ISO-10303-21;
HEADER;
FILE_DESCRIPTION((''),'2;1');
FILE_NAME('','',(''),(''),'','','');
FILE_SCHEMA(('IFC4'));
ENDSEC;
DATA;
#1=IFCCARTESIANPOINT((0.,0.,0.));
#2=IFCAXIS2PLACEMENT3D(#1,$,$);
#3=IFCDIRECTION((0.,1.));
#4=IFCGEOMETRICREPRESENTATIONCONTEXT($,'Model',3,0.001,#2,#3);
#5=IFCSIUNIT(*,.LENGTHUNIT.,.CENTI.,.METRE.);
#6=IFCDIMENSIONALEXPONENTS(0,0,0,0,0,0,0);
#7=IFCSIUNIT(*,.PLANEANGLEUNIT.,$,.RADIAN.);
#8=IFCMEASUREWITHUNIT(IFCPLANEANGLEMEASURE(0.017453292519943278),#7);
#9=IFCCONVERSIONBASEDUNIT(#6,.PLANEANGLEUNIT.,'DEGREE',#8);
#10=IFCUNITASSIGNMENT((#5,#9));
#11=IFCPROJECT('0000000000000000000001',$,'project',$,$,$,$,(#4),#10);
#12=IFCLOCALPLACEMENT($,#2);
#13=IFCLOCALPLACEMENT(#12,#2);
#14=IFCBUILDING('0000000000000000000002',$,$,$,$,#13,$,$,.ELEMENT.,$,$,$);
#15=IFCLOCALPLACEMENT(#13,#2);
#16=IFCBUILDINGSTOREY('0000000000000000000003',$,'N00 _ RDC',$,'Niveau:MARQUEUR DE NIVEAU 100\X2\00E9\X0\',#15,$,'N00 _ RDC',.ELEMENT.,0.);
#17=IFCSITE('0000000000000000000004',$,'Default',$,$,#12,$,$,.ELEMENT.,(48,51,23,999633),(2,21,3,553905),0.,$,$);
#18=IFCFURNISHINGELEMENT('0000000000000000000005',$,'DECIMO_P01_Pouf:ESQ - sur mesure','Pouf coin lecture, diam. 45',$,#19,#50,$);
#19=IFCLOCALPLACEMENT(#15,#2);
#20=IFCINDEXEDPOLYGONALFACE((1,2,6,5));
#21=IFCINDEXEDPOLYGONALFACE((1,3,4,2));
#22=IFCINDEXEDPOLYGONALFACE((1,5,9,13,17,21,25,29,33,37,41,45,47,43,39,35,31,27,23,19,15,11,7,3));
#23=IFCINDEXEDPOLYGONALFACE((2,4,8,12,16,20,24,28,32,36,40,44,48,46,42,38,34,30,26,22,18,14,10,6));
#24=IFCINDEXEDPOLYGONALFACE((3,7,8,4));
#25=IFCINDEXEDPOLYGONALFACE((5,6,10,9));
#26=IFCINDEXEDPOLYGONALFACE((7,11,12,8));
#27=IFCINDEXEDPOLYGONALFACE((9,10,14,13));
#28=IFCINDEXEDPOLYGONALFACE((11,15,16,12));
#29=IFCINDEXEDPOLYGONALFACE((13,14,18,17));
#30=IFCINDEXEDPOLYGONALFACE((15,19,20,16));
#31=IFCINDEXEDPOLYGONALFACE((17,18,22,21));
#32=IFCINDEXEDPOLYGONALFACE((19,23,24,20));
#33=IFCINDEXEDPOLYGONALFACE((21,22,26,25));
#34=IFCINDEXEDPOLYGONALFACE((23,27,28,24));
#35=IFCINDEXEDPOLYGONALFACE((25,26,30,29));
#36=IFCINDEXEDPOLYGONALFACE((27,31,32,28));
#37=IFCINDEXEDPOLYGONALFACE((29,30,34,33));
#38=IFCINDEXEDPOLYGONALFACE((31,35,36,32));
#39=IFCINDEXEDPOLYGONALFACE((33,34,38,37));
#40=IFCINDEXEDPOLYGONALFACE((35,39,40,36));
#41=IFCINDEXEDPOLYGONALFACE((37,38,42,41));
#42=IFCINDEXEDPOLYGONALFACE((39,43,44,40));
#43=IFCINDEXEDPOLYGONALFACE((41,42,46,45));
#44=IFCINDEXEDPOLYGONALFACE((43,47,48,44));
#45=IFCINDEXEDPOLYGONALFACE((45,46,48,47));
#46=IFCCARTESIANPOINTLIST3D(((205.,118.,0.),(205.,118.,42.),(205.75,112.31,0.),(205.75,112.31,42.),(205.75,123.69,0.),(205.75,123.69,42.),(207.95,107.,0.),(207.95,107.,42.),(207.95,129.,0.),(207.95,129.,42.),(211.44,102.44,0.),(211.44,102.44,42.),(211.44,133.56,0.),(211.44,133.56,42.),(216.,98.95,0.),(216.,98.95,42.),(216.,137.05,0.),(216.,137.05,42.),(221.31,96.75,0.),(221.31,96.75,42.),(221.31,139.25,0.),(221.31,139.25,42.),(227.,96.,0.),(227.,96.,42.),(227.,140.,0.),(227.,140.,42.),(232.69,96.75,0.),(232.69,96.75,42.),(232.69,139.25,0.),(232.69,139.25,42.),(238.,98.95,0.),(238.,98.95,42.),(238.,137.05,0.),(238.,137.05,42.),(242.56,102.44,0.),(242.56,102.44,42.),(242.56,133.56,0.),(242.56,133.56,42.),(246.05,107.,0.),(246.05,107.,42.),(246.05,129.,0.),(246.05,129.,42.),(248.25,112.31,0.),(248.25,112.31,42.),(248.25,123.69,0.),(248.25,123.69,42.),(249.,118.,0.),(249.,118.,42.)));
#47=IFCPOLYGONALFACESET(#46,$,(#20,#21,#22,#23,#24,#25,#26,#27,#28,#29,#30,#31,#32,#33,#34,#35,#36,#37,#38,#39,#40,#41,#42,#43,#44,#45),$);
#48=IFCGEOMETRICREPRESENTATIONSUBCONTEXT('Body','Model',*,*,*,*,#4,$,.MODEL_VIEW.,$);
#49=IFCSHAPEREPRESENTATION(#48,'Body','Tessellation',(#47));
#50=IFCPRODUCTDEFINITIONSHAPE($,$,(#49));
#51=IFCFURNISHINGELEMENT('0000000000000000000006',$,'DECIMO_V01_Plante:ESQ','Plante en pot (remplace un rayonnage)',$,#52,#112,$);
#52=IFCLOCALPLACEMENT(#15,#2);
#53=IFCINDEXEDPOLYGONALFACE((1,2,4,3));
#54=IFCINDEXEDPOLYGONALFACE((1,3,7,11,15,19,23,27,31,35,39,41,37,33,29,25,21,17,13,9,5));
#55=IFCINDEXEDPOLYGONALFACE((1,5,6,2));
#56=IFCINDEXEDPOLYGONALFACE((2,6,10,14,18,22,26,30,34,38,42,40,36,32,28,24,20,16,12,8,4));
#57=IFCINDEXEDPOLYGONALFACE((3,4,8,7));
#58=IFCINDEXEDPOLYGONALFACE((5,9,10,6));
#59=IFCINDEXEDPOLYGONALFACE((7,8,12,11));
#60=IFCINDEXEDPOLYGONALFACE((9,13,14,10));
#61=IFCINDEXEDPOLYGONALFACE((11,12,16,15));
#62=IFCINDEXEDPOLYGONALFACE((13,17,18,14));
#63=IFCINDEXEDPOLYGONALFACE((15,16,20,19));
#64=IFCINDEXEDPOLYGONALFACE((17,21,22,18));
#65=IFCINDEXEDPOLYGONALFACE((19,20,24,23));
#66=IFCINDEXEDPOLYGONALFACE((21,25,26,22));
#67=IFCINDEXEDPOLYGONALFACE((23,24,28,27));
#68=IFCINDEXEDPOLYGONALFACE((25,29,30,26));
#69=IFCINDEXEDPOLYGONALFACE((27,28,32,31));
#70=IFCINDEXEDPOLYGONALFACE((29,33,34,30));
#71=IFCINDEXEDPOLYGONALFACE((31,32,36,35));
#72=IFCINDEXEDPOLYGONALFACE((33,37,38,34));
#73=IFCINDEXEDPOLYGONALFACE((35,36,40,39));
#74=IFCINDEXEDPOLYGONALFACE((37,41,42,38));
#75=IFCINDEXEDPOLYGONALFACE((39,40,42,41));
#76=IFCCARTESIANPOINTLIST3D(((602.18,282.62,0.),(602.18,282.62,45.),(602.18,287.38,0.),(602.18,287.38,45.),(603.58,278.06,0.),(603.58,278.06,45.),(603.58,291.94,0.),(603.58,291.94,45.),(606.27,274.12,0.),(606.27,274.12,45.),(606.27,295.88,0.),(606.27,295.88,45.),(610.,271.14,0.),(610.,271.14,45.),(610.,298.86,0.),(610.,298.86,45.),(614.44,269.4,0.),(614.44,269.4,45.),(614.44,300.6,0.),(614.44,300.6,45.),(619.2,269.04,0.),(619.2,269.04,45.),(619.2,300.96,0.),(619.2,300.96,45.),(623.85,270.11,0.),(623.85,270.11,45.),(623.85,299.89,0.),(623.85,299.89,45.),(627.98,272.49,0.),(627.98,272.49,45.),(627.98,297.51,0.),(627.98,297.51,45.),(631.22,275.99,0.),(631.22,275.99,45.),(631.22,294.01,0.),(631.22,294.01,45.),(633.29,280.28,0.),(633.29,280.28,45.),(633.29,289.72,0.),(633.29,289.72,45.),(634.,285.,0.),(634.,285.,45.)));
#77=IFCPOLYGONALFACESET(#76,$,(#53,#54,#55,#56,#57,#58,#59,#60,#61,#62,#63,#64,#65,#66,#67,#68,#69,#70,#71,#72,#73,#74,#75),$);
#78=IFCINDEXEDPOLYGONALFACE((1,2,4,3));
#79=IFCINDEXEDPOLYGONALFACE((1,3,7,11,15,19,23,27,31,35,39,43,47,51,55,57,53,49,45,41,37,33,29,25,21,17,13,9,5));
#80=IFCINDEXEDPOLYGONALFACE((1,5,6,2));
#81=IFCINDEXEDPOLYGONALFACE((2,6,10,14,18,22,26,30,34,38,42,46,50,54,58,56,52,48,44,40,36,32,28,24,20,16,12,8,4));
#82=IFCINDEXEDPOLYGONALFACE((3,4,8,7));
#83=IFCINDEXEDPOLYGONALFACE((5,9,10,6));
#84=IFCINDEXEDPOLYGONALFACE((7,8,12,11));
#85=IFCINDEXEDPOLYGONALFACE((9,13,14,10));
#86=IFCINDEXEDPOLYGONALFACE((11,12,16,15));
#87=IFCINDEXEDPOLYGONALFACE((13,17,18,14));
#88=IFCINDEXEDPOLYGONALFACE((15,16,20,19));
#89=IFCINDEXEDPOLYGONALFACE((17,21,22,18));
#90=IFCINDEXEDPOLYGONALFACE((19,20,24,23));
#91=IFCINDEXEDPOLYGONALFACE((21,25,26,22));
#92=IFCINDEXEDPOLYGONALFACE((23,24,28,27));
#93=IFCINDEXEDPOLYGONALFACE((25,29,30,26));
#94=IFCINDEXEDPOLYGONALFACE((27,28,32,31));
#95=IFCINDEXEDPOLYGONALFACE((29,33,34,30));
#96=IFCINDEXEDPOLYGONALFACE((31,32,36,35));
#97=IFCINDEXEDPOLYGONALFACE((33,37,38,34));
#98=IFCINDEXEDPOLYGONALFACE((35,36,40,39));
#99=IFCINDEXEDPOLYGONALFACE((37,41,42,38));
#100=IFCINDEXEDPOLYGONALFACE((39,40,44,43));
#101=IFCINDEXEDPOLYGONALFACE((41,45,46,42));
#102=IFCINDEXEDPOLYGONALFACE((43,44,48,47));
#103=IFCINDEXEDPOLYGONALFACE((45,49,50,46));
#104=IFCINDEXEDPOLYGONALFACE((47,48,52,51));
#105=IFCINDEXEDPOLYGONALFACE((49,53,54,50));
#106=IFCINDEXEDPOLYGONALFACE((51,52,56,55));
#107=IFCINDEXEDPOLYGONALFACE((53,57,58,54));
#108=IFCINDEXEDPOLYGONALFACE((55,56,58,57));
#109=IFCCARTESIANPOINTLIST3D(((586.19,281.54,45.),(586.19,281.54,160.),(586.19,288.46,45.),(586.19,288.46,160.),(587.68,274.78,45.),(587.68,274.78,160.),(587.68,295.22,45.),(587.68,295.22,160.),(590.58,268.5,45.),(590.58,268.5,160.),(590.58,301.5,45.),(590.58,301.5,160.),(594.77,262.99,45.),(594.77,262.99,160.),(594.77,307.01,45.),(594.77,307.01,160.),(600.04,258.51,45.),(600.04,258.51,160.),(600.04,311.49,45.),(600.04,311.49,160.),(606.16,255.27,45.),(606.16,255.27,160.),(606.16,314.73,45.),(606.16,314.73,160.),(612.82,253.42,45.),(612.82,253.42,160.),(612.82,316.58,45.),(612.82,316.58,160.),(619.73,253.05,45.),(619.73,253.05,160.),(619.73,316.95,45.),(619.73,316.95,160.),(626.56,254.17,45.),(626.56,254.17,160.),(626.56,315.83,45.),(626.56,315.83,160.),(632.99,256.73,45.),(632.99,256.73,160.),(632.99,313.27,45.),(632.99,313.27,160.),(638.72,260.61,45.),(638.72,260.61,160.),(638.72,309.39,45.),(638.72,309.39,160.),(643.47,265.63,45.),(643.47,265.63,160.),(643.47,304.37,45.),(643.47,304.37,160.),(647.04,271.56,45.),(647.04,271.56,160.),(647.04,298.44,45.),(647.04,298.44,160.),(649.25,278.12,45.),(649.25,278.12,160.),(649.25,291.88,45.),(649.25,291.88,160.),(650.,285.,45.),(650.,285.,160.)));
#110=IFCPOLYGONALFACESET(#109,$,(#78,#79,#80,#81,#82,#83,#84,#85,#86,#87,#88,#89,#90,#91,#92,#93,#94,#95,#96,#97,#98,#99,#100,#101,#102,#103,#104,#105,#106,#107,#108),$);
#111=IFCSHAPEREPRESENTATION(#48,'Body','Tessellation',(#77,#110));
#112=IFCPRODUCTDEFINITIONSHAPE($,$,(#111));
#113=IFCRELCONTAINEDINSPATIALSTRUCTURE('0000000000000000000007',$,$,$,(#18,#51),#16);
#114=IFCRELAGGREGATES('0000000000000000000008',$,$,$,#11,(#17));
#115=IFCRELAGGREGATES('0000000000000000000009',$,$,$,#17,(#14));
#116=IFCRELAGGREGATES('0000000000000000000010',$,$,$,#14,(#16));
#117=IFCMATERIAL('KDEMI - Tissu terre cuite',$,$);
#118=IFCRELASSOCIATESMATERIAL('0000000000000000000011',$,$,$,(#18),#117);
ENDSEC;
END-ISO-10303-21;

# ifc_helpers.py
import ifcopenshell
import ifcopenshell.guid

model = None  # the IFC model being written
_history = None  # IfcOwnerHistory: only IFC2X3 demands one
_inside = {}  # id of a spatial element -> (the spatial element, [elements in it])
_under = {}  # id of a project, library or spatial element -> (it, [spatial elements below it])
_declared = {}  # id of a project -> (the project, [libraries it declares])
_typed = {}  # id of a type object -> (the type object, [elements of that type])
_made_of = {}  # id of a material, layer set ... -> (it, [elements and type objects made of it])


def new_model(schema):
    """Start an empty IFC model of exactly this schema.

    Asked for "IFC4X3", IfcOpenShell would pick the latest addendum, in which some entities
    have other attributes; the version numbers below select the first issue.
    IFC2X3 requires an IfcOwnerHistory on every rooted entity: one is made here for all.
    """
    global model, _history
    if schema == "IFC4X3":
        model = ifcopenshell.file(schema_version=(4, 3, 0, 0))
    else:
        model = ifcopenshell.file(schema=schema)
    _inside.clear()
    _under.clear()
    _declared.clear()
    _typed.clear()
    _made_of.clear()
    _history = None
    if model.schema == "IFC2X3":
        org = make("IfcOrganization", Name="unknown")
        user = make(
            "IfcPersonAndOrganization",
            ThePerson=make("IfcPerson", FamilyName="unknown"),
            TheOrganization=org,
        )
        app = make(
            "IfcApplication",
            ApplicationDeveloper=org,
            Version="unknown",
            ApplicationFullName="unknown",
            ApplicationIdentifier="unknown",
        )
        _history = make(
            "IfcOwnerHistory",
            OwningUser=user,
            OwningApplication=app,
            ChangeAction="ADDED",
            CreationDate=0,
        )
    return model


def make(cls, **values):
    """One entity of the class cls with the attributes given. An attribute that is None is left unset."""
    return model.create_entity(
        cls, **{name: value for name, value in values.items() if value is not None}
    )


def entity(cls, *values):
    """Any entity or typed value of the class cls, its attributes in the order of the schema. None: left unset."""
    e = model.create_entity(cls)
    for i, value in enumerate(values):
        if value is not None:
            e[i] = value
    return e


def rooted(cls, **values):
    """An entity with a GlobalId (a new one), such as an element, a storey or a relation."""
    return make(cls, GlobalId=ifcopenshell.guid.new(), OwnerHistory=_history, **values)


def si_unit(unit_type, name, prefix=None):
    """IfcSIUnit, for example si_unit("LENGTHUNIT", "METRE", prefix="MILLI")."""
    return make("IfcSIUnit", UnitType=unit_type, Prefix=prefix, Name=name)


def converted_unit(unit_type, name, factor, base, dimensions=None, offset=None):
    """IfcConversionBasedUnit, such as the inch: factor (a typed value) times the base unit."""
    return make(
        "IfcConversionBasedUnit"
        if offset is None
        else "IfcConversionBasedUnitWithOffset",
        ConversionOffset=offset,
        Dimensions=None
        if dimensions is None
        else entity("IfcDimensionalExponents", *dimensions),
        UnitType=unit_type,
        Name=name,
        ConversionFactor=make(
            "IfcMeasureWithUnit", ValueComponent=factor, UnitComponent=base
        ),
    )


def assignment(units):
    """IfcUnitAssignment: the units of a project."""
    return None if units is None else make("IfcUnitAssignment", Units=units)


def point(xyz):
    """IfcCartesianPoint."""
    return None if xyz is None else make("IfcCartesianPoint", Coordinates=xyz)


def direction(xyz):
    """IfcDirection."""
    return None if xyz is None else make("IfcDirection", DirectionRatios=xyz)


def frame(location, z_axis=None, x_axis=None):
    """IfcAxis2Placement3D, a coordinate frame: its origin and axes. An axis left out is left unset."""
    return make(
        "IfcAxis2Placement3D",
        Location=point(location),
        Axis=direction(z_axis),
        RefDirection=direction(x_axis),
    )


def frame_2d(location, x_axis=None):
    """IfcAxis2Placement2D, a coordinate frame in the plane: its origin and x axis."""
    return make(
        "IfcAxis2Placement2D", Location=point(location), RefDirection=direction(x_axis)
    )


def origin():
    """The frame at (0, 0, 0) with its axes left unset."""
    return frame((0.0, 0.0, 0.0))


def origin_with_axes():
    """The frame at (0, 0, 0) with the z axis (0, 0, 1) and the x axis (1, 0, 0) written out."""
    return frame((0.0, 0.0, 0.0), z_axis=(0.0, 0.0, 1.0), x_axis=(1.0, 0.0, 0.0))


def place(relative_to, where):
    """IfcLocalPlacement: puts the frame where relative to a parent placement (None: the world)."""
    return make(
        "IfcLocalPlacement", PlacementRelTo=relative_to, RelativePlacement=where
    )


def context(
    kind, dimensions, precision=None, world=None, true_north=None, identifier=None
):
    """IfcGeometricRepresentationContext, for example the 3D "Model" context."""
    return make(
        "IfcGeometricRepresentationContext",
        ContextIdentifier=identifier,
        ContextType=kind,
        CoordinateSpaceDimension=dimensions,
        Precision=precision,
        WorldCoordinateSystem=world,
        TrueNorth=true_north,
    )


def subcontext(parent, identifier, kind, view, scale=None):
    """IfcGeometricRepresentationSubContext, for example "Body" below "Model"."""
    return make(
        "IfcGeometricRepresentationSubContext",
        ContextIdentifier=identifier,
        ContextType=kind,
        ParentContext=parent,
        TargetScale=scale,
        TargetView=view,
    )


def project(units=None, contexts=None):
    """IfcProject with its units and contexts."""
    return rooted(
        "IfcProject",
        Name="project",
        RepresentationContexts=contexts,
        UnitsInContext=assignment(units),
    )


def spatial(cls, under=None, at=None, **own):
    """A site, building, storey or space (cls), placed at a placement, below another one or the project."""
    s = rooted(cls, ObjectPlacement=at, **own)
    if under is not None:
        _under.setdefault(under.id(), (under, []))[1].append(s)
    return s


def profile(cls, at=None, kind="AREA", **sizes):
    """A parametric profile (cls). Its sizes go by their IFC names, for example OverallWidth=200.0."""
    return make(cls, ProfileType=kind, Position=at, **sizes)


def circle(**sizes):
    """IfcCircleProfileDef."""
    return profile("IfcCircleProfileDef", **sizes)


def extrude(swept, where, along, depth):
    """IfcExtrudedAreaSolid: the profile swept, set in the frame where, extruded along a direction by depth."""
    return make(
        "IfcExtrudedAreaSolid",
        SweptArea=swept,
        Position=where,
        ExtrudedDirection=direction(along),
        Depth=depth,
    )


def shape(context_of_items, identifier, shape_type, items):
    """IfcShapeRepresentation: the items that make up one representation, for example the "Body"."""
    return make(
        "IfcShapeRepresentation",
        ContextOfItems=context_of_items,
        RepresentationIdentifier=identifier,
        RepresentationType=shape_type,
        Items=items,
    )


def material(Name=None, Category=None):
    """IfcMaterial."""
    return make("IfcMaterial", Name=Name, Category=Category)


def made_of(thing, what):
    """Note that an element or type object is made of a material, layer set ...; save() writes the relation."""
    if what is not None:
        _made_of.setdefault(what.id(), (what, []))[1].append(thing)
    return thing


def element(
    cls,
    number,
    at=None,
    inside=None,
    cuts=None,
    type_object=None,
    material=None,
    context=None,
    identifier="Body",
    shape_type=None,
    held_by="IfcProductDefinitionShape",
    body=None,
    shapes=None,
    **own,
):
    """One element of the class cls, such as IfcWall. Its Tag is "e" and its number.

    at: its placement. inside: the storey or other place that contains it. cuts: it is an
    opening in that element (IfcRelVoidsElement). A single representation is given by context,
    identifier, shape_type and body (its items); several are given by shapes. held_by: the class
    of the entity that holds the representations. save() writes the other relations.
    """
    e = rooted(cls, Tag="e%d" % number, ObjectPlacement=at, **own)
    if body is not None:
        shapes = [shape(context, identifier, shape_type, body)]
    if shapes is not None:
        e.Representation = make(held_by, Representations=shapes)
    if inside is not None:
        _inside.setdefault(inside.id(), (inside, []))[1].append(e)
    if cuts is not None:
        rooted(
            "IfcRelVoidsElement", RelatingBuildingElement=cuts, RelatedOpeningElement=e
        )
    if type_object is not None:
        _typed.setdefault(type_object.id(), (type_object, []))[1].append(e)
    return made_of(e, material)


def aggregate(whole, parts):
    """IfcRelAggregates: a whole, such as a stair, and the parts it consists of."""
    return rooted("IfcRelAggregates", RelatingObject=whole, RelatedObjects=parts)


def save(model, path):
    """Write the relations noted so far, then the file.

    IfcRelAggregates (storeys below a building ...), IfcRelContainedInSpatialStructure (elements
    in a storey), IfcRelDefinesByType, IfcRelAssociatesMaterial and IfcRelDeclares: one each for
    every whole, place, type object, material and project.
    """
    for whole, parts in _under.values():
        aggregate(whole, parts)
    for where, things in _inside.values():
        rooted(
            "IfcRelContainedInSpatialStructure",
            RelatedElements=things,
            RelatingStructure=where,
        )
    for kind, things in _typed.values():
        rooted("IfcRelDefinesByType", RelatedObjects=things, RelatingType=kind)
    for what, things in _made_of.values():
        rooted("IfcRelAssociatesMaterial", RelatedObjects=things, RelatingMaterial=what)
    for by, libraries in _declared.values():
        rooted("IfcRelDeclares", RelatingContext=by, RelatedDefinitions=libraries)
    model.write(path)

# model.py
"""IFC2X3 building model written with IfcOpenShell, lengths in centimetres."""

from ifc_helpers import new_model, entity, si_unit, converted_unit, direction, frame, frame_2d, origin, origin_with_axes, place, context, subcontext, project, spatial, circle, extrude, material, element, save


model = new_model("IFC2X3")

# Units and contexts
model_context = context("Model", 3, precision=0.001, world=origin(), true_north=direction((0.0, 1.0)))
body_context = subcontext(model_context, "Body", "Model", "MODEL_VIEW")
ifc_project = project(units=[si_unit("LENGTHUNIT", "METRE", prefix="CENTI"), converted_unit("PLANEANGLEUNIT", "DEGREE", entity("IfcPlaneAngleMeasure", 0.017453292519943278), si_unit("PLANEANGLEUNIT", "RADIAN"), dimensions=[0, 0, 0, 0, 0, 0, 0])], contexts=[model_context])

# Site, building, storey
site_placement = place(None, origin())
site = spatial("IfcSite", under=ifc_project, at=site_placement, Name="Default", CompositionType="ELEMENT", RefLatitude=(48, 51, 23, 999633), RefLongitude=(2, 21, 3, 553905), RefElevation=0.0)
building_placement = place(site_placement, origin())
building = spatial("IfcBuilding", under=site, at=building_placement, CompositionType="ELEMENT")
storey_placement = place(building_placement, origin())
storey = spatial("IfcBuildingStorey", under=building, at=storey_placement, Name="N00 _ RDC", ObjectType="Niveau:MARQUEUR DE NIVEAU 100é", LongName="N00 _ RDC", CompositionType="ELEMENT", Elevation=0.0)

# Furnishing elements
ifc_material_1 = material(Name="KDEMI - Tissu terre cuite")
furnishing_1_placement = place(storey_placement, origin_with_axes())
element("IfcFurnishingElement", 1, at=furnishing_1_placement, inside=storey, material=ifc_material_1, Name="DECIMO_P01_Pouf:ESQ - sur mesure", Description="Pouf coin lecture, diam. 45", context=body_context, shape_type="SweptSolid", body=[
    extrude(circle(Radius=22.0, at=frame_2d((227.0, 118.0))), origin(), (0.0, 0.0, 1.0), 42.0),
])
furnishing_2_placement = place(storey_placement, origin_with_axes())
element("IfcFurnishingElement", 2, at=furnishing_2_placement, inside=storey, Name="DECIMO_V01_Plante:ESQ", Description="Plante en pot (remplace un rayonnage)", context=body_context, shape_type="SweptSolid", body=[
    extrude(circle(Radius=16.0, at=frame_2d((618.0, 285.0))), origin(), (0.0, 0.0, 1.0), 45.0),
    extrude(circle(Radius=32.0, at=frame_2d((618.0, 285.0))), frame((0.0, 0.0, 45.0)), (0.0, 0.0, 1.0), 115.0),
])

save(model, "model.ifc")
